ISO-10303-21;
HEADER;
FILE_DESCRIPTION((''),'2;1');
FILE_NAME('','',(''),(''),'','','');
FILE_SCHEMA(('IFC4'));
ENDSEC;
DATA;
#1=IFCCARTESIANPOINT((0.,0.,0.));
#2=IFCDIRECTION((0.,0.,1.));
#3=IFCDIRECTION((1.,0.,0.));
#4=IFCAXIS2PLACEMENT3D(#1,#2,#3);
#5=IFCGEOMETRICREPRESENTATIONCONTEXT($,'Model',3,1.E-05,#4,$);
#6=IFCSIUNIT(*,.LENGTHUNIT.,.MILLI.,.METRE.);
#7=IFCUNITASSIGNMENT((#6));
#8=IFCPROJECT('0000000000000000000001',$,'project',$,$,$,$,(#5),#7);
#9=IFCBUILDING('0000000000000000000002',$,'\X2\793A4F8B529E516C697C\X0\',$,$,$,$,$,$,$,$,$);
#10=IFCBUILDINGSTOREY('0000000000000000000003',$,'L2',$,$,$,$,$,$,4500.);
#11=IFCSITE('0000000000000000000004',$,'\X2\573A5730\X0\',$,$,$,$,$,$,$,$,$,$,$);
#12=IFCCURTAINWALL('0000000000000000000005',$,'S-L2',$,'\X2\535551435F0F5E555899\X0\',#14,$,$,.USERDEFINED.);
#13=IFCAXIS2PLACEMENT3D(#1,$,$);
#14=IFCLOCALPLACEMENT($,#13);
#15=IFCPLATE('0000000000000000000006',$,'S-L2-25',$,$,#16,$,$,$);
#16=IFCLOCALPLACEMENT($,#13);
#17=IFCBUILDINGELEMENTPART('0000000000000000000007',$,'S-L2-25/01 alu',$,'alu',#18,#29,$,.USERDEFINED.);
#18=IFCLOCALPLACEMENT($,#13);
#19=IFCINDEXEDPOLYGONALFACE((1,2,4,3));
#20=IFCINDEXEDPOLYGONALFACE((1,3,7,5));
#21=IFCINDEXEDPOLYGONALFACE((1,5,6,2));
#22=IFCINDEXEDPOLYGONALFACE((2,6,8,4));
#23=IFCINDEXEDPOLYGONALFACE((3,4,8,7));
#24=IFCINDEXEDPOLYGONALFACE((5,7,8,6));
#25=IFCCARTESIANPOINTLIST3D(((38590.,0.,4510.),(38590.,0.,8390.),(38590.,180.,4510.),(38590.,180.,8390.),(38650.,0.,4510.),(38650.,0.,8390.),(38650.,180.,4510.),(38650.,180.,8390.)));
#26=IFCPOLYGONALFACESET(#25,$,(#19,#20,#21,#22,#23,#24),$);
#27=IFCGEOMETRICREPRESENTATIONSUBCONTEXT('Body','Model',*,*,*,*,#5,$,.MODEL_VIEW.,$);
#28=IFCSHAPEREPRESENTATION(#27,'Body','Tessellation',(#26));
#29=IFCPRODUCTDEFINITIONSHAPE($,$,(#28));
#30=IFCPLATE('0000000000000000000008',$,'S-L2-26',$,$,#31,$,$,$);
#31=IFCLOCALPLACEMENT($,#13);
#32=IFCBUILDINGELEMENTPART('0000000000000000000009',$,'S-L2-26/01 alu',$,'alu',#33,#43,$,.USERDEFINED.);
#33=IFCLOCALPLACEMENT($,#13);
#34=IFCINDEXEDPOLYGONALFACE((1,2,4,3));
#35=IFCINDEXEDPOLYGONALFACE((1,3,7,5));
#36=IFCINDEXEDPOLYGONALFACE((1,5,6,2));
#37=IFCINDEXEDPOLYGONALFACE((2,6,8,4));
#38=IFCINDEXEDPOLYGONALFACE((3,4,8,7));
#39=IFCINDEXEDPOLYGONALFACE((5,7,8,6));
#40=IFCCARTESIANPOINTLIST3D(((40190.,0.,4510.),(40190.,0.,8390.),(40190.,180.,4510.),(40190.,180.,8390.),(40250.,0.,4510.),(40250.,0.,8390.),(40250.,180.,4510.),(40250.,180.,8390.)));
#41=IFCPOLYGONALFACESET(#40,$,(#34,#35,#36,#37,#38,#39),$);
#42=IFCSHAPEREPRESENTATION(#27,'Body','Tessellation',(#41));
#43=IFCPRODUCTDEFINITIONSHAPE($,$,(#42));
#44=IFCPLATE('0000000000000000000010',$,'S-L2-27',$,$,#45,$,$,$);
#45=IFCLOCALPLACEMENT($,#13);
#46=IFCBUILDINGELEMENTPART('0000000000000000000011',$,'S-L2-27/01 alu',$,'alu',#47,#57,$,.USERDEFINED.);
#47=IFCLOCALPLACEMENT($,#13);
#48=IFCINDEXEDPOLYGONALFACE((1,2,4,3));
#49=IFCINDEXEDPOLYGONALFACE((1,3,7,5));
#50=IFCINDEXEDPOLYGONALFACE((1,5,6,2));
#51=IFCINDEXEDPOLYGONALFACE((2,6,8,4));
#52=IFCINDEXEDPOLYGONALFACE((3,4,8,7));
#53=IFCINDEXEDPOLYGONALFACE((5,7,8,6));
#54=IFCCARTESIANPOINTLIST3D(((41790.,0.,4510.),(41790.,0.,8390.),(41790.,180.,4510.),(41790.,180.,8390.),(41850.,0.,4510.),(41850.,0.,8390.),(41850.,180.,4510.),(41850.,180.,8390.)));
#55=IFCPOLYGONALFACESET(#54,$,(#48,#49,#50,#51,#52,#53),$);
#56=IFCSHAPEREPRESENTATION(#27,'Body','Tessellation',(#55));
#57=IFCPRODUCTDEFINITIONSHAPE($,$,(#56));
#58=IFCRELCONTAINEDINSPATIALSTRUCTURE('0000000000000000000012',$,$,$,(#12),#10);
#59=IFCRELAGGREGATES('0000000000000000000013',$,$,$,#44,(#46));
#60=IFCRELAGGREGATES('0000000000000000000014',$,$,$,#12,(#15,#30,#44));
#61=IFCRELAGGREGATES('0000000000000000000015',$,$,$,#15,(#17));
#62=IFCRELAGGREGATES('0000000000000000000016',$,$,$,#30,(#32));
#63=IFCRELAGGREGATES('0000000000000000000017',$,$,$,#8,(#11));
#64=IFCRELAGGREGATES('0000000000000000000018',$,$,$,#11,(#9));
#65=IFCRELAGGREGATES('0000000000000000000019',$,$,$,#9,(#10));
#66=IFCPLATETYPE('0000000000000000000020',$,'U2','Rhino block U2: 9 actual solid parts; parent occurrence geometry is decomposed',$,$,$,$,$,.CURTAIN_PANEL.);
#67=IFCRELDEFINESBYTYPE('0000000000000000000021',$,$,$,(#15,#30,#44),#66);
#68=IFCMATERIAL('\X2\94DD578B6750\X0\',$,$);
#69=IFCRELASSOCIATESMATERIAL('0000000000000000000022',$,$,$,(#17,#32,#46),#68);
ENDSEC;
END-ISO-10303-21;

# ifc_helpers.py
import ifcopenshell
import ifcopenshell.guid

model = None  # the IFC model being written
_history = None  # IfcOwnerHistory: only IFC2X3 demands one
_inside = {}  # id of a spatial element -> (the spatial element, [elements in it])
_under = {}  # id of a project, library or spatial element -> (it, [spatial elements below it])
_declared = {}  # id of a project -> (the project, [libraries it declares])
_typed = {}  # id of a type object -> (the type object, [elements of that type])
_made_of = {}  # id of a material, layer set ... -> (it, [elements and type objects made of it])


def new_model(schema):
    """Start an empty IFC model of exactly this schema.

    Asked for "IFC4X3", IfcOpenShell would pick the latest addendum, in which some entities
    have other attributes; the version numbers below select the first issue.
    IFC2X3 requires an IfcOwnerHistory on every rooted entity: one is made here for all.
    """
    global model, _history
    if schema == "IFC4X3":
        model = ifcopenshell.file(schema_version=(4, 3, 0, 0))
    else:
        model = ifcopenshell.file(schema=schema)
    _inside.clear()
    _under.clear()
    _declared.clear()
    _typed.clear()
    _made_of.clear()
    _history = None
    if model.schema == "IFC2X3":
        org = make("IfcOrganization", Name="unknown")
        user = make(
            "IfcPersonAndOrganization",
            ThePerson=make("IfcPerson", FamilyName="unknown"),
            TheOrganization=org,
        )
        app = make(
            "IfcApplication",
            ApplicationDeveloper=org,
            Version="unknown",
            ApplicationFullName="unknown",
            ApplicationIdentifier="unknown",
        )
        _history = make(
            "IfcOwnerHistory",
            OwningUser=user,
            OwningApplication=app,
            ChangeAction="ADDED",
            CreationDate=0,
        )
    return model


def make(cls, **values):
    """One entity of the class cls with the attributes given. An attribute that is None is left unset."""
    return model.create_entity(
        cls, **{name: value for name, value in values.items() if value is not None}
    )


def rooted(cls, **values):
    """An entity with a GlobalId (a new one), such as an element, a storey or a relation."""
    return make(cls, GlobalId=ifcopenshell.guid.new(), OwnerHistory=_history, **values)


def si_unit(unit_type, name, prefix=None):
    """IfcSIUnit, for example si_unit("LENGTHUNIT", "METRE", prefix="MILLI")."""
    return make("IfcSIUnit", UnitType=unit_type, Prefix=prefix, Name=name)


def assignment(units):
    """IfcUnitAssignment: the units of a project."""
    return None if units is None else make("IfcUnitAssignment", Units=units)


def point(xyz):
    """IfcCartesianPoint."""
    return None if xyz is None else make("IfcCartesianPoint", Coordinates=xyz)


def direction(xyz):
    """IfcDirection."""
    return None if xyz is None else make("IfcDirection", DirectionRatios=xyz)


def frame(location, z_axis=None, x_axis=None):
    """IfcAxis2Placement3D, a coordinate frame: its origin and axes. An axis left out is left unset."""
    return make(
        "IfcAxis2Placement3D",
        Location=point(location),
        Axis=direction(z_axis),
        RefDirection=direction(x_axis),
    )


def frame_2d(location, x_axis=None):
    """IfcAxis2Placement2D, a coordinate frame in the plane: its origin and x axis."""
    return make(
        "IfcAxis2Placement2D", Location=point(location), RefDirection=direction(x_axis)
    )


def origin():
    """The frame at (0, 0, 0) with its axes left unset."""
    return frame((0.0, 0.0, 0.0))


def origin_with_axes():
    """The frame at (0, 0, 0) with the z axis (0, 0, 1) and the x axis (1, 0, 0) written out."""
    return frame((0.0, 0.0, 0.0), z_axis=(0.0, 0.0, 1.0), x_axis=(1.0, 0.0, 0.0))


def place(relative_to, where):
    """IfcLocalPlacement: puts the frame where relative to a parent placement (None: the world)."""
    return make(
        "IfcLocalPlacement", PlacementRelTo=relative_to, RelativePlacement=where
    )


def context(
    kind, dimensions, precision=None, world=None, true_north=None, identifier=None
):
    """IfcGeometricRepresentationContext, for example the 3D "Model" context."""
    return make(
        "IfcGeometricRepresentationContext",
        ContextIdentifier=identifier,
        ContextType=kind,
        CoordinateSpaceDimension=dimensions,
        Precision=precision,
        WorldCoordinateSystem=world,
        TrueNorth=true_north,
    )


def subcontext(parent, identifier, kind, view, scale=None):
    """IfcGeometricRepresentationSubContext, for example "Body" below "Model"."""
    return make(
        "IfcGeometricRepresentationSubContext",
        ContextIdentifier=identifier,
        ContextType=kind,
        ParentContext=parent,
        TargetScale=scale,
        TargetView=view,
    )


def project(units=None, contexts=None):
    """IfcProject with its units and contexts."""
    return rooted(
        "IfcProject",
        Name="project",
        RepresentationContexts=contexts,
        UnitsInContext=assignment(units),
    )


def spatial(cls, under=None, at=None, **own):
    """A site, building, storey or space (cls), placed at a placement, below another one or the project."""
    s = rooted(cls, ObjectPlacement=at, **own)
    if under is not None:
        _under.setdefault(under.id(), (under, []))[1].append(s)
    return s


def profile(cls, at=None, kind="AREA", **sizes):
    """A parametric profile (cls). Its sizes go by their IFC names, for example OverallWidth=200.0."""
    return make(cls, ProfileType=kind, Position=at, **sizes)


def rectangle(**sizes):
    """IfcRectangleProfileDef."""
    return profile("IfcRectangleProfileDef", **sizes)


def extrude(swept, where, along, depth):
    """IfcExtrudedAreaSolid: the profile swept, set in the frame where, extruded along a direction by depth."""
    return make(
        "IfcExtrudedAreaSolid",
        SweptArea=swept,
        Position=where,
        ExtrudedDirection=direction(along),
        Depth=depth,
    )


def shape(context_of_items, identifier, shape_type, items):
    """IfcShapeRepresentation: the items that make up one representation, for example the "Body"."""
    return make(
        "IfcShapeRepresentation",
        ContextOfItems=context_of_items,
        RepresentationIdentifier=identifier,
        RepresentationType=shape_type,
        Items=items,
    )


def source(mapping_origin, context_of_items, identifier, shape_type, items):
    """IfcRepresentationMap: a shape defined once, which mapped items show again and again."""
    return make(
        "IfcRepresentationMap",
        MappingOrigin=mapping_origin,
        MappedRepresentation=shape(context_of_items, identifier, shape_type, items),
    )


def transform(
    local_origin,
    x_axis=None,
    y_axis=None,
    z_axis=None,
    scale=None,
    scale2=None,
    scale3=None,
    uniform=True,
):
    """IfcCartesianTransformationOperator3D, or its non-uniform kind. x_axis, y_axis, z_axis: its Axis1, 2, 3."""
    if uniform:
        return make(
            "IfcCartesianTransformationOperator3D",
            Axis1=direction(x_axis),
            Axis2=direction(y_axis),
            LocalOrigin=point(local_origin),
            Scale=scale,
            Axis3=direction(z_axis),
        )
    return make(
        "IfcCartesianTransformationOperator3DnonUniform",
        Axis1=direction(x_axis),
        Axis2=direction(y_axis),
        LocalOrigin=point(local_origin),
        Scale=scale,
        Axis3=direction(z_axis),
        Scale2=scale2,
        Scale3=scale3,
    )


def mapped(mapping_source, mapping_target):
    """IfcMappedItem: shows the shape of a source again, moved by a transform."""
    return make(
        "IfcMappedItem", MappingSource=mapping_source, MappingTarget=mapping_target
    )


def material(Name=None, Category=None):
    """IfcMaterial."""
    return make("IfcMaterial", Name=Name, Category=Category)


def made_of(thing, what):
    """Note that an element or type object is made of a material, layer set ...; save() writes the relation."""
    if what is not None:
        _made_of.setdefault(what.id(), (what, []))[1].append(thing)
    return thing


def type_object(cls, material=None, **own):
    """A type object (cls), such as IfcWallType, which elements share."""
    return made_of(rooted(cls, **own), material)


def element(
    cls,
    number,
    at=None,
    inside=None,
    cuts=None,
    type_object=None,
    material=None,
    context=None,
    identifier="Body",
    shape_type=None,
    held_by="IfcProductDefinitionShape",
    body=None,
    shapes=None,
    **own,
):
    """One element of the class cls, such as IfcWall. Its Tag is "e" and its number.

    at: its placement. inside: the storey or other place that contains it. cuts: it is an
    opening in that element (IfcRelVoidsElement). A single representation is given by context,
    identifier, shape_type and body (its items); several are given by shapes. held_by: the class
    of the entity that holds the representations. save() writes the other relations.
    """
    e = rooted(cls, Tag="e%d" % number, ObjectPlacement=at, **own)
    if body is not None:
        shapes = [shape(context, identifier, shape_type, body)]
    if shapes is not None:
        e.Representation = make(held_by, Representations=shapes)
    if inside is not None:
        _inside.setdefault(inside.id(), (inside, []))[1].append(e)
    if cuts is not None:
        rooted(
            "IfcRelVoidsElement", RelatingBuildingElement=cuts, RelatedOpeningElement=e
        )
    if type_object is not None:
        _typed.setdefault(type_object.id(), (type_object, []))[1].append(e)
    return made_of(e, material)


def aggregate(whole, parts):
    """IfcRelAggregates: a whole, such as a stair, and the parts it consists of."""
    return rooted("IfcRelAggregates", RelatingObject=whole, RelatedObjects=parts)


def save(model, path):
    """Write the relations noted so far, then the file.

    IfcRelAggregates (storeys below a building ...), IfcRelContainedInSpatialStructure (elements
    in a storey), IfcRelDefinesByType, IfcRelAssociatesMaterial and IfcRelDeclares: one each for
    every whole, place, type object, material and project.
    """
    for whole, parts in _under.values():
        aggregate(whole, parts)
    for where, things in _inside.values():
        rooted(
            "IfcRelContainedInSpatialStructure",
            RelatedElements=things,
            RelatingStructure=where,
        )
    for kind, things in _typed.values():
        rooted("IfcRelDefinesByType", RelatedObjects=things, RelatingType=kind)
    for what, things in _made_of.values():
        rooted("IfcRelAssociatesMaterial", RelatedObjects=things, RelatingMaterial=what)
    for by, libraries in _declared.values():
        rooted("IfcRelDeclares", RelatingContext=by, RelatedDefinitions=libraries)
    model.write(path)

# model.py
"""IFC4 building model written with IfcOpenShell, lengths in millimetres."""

from ifc_helpers import new_model, si_unit, frame, frame_2d, origin, origin_with_axes, place, context, subcontext, project, spatial, rectangle, extrude, source, transform, mapped, material, type_object, element, aggregate, save


model = new_model("IFC4")

# Units and contexts
model_context = context("Model", 3, precision=1e-05, world=origin_with_axes())
body_context = subcontext(model_context, "Body", "Model", "MODEL_VIEW")
ifc_project = project(units=[si_unit("LENGTHUNIT", "METRE", prefix="MILLI")], contexts=[model_context])

# Site, building, storey
site = spatial("IfcSite", under=ifc_project, Name="场地")
building = spatial("IfcBuilding", under=site, Name="示例办公楼")
storey = spatial("IfcBuildingStorey", under=building, Name="L2", Elevation=4500.0)

# Curtain wall, plates, building element parts
curtain_wall = element("IfcCurtainWall", 1, inside=storey, Name="S-L2", ObjectType="单元式幕墙", PredefinedType="USERDEFINED")
plate_type = type_object("IfcPlateType", Name="U2", Description="Rhino block U2: 9 actual solid parts; parent occurrence geometry is decomposed", PredefinedType="CURTAIN_PANEL")
plate_1_placement = place(None, frame((38590.0, 0.0, 4510.0), z_axis=(0.0, 0.0, 1.0), x_axis=(1.0, 0.0, 0.0)))
plate_1 = element("IfcPlate", 2, at=plate_1_placement, type_object=plate_type, Name="S-L2-25")
ifc_material_1 = material(Name="铝型材")
shared_shape_1 = source(origin(), body_context, "Body", "SweptSolid", [
    extrude(rectangle(XDim=60.0, YDim=180.0, at=frame_2d((30.0, 90.0))), origin(), (0.0, 0.0, 1.0), 3880.0),
])
building_element_part_1_placement = place(plate_1_placement, origin())
building_element_part_1 = element("IfcBuildingElementPart", 3, at=building_element_part_1_placement, material=ifc_material_1, Name="S-L2-25/01 alu", ObjectType="alu", PredefinedType="USERDEFINED", context=body_context, shape_type="MappedRepresentation", body=[
    mapped(shared_shape_1, transform((0.0, 0.0, 0.0))),
])
plate_2_placement = place(None, frame((40190.0, 0.0, 4510.0), z_axis=(0.0, 0.0, 1.0), x_axis=(1.0, 0.0, 0.0)))
plate_2 = element("IfcPlate", 4, at=plate_2_placement, type_object=plate_type, Name="S-L2-26")
building_element_part_2_placement = place(plate_2_placement, origin())
building_element_part_2 = element("IfcBuildingElementPart", 5, at=building_element_part_2_placement, material=ifc_material_1, Name="S-L2-26/01 alu", ObjectType="alu", PredefinedType="USERDEFINED", context=body_context, shape_type="MappedRepresentation", body=[
    mapped(shared_shape_1, transform((0.0, 0.0, 0.0))),
])
plate_3_placement = place(None, frame((41790.0, 0.0, 4510.0), z_axis=(0.0, 0.0, 1.0), x_axis=(1.0, 0.0, 0.0)))
plate_3 = element("IfcPlate", 6, at=plate_3_placement, type_object=plate_type, Name="S-L2-27")
building_element_part_3_placement = place(plate_3_placement, origin())
building_element_part_3 = element("IfcBuildingElementPart", 7, at=building_element_part_3_placement, material=ifc_material_1, Name="S-L2-27/01 alu", ObjectType="alu", PredefinedType="USERDEFINED", context=body_context, shape_type="MappedRepresentation", body=[
    mapped(shared_shape_1, transform((0.0, 0.0, 0.0))),
])
aggregate(plate_3, [building_element_part_3])
aggregate(curtain_wall, [plate_1, plate_2, plate_3])
aggregate(plate_1, [building_element_part_1])
aggregate(plate_2, [building_element_part_2])

save(model, "model.ifc")
